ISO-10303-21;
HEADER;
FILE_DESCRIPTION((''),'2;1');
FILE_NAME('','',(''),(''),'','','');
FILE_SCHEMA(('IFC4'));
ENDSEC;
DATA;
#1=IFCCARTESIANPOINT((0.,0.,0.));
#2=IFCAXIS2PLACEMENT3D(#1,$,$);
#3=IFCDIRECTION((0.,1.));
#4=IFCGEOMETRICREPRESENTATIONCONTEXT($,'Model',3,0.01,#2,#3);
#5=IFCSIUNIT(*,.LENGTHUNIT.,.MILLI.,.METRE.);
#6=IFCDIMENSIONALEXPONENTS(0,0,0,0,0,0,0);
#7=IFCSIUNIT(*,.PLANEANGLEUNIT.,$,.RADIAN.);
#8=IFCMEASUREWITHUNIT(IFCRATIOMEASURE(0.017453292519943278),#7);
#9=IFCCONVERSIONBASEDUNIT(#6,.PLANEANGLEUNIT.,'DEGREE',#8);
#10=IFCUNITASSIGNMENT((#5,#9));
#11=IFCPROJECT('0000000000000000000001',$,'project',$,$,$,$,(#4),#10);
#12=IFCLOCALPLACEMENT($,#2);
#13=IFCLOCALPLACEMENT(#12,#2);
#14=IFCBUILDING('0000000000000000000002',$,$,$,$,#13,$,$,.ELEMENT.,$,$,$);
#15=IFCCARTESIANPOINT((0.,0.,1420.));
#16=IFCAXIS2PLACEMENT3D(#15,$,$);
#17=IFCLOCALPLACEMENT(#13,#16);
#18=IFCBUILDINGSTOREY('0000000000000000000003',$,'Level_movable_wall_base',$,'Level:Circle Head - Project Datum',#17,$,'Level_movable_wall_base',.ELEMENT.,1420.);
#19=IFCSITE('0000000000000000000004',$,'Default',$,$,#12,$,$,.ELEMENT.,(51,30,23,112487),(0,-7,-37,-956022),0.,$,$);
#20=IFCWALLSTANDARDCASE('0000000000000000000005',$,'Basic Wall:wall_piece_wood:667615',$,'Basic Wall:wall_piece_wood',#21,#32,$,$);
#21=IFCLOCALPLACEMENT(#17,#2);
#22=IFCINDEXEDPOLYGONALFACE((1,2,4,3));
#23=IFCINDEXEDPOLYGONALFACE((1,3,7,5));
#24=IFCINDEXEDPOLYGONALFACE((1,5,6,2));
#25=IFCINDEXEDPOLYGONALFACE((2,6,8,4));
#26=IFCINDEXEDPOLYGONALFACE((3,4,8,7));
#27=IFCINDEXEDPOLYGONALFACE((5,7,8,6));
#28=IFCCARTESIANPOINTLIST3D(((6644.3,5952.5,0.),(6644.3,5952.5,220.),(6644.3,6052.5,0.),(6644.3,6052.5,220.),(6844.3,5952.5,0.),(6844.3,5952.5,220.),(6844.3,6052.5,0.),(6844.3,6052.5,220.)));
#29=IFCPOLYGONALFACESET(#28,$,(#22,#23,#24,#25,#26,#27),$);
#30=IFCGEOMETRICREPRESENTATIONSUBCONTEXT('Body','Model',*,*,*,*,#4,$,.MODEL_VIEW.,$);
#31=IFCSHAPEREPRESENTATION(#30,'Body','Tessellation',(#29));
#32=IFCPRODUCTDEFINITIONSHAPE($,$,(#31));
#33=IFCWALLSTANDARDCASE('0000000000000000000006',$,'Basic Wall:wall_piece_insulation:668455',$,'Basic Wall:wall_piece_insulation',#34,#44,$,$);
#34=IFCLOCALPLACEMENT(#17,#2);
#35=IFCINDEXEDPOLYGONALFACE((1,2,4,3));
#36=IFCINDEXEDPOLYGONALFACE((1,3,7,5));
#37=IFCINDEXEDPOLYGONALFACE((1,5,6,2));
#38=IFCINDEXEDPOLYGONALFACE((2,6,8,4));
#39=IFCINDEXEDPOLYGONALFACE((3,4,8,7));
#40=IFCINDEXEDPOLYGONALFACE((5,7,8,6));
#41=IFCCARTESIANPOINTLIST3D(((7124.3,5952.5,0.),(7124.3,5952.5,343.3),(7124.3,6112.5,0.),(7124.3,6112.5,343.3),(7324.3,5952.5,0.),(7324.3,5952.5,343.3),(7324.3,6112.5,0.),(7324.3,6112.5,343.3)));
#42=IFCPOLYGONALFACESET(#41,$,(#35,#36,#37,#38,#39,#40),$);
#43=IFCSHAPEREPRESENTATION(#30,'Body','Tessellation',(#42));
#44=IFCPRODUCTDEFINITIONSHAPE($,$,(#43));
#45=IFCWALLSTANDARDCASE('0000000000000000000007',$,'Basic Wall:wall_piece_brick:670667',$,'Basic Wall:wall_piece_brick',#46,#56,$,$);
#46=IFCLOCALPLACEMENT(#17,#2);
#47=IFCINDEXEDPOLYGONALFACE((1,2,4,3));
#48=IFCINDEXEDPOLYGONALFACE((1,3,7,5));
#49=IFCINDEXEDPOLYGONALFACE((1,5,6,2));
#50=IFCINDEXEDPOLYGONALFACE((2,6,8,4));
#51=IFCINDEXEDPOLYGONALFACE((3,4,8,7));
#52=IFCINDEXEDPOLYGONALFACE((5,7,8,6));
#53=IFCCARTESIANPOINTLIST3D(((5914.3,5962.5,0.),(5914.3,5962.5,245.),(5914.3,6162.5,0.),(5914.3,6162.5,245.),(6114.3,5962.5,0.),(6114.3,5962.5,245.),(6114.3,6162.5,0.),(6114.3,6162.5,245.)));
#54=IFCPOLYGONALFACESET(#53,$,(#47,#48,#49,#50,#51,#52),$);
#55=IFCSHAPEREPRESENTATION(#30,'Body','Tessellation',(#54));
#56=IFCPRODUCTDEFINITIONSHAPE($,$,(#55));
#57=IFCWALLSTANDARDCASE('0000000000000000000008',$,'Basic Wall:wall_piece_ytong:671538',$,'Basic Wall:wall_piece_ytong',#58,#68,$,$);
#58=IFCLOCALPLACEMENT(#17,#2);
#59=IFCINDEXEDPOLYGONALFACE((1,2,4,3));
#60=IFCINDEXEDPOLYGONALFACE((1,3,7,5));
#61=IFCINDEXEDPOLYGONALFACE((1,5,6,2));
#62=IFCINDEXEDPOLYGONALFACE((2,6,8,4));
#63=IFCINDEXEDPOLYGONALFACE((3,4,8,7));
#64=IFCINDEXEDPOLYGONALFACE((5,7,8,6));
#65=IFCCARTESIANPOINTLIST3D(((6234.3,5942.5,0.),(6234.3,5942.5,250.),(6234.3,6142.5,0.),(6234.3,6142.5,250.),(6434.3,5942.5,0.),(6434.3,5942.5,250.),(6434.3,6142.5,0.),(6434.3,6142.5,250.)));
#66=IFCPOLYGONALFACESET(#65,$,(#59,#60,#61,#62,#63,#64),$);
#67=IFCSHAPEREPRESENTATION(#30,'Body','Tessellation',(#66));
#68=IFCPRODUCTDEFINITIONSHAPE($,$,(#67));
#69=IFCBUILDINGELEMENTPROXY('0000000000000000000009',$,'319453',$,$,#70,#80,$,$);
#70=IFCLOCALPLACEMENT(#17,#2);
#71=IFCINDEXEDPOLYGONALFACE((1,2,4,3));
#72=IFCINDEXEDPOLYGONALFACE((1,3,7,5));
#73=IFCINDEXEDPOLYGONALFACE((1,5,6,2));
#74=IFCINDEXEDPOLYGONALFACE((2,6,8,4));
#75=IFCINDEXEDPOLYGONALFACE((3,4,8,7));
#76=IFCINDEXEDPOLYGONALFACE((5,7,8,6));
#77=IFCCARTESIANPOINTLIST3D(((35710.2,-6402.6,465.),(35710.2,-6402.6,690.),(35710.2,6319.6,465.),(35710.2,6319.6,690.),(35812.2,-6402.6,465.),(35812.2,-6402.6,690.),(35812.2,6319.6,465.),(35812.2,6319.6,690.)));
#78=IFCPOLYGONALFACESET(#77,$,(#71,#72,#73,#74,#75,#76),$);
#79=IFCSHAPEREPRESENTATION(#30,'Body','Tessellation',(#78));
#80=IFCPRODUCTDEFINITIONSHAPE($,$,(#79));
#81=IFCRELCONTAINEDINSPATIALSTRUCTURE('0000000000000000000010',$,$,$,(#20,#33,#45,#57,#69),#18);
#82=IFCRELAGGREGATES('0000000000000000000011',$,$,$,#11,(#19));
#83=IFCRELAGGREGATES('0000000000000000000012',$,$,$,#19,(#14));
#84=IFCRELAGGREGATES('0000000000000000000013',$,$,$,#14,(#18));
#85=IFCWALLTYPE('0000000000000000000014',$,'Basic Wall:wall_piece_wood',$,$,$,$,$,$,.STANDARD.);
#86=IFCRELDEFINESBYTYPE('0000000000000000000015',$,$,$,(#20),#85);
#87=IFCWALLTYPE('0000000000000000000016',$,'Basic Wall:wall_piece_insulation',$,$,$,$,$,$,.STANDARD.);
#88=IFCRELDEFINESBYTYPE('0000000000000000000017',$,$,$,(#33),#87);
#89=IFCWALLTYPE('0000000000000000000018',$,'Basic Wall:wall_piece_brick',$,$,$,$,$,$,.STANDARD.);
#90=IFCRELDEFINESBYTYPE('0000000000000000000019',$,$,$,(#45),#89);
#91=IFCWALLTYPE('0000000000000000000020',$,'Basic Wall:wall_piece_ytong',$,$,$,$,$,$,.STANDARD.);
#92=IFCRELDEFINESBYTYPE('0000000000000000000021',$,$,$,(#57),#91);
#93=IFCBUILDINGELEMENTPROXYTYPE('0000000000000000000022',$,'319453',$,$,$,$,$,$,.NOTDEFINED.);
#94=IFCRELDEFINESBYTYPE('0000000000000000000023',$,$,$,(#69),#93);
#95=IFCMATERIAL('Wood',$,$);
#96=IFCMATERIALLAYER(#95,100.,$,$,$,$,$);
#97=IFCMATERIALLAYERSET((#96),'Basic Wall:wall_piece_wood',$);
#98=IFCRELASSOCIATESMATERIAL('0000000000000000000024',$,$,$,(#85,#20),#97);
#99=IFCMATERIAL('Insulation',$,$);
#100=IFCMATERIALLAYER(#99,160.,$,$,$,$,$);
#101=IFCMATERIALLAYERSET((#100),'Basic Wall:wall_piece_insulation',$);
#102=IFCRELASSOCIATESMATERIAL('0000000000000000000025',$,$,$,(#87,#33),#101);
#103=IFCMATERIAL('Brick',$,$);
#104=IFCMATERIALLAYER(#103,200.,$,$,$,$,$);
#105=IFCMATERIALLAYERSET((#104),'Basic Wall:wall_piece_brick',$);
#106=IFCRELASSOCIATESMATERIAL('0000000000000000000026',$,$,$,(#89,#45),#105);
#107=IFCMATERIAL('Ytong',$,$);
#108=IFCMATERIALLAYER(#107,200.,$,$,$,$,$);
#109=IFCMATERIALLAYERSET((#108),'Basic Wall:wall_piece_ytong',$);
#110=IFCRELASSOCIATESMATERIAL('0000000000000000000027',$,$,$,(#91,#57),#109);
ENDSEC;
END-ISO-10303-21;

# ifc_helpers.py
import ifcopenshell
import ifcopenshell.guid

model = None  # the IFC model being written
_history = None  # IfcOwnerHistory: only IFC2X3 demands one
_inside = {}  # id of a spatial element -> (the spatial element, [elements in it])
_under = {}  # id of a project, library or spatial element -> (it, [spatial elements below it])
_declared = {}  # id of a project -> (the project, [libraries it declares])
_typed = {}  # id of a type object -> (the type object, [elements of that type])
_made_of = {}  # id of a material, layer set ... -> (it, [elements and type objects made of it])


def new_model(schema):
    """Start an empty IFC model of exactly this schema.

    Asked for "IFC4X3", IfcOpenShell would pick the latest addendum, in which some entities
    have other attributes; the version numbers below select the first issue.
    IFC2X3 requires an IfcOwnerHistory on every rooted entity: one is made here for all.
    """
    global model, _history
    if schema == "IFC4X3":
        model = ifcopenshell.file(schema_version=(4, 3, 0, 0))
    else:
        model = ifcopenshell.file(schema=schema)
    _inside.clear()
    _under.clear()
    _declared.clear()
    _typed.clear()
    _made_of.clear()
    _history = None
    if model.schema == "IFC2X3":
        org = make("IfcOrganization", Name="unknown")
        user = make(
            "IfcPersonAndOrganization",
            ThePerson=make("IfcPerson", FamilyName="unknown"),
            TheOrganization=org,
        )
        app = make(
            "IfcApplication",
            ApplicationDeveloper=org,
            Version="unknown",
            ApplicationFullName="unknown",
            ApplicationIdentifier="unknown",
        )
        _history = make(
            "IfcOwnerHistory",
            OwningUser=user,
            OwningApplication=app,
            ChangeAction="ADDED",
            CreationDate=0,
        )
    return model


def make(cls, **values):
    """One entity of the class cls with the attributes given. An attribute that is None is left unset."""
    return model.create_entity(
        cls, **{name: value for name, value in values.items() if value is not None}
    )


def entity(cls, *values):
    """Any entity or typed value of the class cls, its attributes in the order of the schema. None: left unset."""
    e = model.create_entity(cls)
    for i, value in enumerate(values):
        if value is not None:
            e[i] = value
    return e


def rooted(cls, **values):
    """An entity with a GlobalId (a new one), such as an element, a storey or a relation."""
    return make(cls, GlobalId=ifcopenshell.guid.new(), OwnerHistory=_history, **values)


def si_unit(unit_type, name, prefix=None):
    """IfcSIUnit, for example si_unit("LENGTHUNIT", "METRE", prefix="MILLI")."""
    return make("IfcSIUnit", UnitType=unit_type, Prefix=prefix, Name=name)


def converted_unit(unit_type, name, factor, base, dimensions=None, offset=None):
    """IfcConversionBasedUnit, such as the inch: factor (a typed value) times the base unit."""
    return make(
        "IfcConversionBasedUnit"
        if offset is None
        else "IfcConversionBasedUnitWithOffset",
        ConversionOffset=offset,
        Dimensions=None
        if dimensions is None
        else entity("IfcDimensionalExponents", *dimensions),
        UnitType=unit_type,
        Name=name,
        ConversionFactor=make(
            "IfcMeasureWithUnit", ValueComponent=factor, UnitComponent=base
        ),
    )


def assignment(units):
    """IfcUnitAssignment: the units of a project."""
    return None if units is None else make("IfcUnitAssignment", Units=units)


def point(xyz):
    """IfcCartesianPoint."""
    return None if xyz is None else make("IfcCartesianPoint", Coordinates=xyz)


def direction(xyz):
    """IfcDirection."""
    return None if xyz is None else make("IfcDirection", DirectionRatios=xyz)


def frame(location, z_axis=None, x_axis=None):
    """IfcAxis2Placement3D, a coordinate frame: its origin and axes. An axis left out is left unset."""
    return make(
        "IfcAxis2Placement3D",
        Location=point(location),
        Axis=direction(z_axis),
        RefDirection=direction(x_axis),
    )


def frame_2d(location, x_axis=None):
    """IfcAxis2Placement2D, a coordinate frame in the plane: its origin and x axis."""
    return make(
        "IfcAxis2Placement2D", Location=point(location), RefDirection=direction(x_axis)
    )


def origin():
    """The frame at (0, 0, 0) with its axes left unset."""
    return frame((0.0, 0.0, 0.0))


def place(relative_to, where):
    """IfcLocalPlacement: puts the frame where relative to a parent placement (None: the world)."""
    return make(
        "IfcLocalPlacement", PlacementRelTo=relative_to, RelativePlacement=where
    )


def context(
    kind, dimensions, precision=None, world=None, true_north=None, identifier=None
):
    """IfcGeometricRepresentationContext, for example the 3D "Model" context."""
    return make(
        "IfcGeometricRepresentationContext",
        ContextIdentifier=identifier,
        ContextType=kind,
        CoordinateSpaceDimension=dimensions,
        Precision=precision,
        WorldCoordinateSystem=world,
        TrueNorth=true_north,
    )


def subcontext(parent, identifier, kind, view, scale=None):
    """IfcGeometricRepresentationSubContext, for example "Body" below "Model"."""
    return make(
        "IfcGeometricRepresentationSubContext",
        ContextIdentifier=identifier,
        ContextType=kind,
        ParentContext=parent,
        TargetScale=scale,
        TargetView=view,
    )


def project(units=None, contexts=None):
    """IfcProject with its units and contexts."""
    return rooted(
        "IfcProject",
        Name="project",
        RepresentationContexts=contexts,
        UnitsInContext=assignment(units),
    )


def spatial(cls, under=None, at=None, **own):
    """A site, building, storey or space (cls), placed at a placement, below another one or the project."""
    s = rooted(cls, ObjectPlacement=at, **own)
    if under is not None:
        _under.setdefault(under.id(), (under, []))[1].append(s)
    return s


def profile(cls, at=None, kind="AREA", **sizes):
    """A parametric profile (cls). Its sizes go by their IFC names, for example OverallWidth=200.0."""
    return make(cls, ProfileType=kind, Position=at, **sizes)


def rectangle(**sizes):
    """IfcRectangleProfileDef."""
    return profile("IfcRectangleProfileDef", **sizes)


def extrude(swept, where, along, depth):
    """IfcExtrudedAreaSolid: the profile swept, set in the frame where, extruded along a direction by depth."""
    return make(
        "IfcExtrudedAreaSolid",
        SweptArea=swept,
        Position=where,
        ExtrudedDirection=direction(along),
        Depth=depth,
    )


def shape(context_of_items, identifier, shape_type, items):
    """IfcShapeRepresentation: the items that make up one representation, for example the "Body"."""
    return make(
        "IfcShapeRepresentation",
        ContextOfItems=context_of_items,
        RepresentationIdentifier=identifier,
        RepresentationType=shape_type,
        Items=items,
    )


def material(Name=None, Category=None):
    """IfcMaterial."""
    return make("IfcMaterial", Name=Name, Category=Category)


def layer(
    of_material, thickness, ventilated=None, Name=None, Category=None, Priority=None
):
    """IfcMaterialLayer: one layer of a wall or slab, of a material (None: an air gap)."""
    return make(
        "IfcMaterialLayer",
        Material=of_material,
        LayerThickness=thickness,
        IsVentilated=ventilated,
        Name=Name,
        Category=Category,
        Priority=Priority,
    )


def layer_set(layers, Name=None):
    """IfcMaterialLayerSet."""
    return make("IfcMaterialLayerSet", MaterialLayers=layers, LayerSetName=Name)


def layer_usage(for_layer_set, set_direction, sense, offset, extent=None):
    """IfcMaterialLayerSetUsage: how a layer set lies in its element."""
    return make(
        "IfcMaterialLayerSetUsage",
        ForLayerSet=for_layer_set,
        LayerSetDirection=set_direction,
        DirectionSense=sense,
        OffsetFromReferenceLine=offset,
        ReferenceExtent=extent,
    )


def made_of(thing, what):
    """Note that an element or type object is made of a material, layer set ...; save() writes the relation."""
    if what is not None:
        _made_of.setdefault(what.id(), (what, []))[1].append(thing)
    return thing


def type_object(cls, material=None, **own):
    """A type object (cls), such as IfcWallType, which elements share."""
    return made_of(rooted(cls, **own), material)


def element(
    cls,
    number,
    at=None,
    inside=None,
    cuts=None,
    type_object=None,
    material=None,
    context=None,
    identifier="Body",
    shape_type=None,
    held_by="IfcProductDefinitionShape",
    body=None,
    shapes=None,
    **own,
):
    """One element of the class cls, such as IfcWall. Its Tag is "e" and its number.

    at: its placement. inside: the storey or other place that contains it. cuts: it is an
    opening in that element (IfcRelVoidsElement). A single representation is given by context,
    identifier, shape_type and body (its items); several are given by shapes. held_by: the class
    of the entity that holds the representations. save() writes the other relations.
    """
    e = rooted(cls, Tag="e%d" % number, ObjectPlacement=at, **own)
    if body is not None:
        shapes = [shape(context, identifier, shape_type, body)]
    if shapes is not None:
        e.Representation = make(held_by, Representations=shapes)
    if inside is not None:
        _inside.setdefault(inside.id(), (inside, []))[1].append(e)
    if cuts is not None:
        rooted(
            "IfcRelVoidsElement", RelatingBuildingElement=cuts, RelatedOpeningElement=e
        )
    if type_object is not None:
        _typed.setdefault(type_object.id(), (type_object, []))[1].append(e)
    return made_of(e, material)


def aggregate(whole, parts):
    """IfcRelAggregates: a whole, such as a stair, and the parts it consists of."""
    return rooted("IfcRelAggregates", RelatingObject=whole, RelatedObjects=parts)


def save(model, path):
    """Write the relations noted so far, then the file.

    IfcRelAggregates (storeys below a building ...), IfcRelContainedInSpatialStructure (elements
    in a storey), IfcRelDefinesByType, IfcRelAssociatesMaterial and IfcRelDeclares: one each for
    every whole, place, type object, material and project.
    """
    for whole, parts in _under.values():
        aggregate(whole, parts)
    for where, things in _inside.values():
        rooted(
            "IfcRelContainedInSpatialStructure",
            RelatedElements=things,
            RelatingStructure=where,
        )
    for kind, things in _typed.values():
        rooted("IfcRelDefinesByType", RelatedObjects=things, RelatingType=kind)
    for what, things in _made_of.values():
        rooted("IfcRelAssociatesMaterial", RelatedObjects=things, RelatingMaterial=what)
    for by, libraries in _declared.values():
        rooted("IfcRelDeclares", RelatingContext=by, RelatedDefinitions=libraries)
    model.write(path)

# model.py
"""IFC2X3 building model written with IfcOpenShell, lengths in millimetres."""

from ifc_helpers import new_model, entity, si_unit, converted_unit, direction, frame, frame_2d, origin, place, context, subcontext, project, spatial, rectangle, extrude, material, layer, layer_set, layer_usage, type_object, element, save


model = new_model("IFC2X3")

# Units and contexts
model_context = context("Model", 3, precision=0.01, world=origin(), true_north=direction((0.0, 1.0)))
body_context = subcontext(model_context, "Body", "Model", "MODEL_VIEW")
ifc_project = project(units=[si_unit("LENGTHUNIT", "METRE", prefix="MILLI"), converted_unit("PLANEANGLEUNIT", "DEGREE", entity("IfcRatioMeasure", 0.017453292519943278), si_unit("PLANEANGLEUNIT", "RADIAN"), dimensions=[0, 0, 0, 0, 0, 0, 0])], contexts=[model_context])

# Site, building, storey
site_placement = place(None, origin())
site = spatial("IfcSite", under=ifc_project, at=site_placement, Name="Default", CompositionType="ELEMENT", RefLatitude=(51, 30, 23, 112487), RefLongitude=(0, -7, -37, -956022), RefElevation=0.0)
building_placement = place(site_placement, origin())
building = spatial("IfcBuilding", under=site, at=building_placement, CompositionType="ELEMENT")
storey_placement = place(building_placement, frame((0.0, 0.0, 1420.0)))
storey = spatial("IfcBuildingStorey", under=building, at=storey_placement, Name="Level_movable_wall_base", ObjectType="Level:Circle Head - Project Datum", LongName="Level_movable_wall_base", CompositionType="ELEMENT", Elevation=1420.0)

# Walls
ifc_material_1 = material(Name="Wood")
ifc_layer_1 = layer(ifc_material_1, 100.0)
ifc_layer_set_1 = layer_set([ifc_layer_1], Name="Basic Wall:wall_piece_wood")
ifc_layer_usage_1 = layer_usage(ifc_layer_set_1, "AXIS2", "NEGATIVE", 50.0)
wall_type_1 = type_object("IfcWallType", Name="Basic Wall:wall_piece_wood", PredefinedType="STANDARD", material=ifc_layer_set_1)
wall_1_placement = place(storey_placement, frame((6644.3, 6002.5, 0.0)))
element("IfcWallStandardCase", 1, at=wall_1_placement, inside=storey, type_object=wall_type_1, material=ifc_layer_usage_1, Name="Basic Wall:wall_piece_wood:667615", ObjectType="Basic Wall:wall_piece_wood", context=body_context, shape_type="SweptSolid", body=[
    extrude(rectangle(XDim=200.0, YDim=100.0, at=frame_2d((100.0, 0.0), x_axis=(-1.0, 0.0))), origin(), (0.0, 0.0, 1.0), 220.0),
])
ifc_material_2 = material(Name="Insulation")
ifc_layer_2 = layer(ifc_material_2, 160.0)
ifc_layer_set_2 = layer_set([ifc_layer_2], Name="Basic Wall:wall_piece_insulation")
ifc_layer_usage_2 = layer_usage(ifc_layer_set_2, "AXIS2", "NEGATIVE", 80.0)
wall_type_2 = type_object("IfcWallType", Name="Basic Wall:wall_piece_insulation", PredefinedType="STANDARD", material=ifc_layer_set_2)
wall_2_placement = place(storey_placement, frame((7124.3, 6032.5, 0.0)))
element("IfcWallStandardCase", 2, at=wall_2_placement, inside=storey, type_object=wall_type_2, material=ifc_layer_usage_2, Name="Basic Wall:wall_piece_insulation:668455", ObjectType="Basic Wall:wall_piece_insulation", context=body_context, shape_type="SweptSolid", body=[
    extrude(rectangle(XDim=200.0, YDim=160.0, at=frame_2d((100.0, 0.0), x_axis=(-1.0, 0.0))), origin(), (0.0, 0.0, 1.0), 343.3),
])
ifc_material_3 = material(Name="Brick")
ifc_layer_3 = layer(ifc_material_3, 200.0)
ifc_layer_set_3 = layer_set([ifc_layer_3], Name="Basic Wall:wall_piece_brick")
ifc_layer_usage_3 = layer_usage(ifc_layer_set_3, "AXIS2", "NEGATIVE", 100.0)
wall_type_3 = type_object("IfcWallType", Name="Basic Wall:wall_piece_brick", PredefinedType="STANDARD", material=ifc_layer_set_3)
wall_3_placement = place(storey_placement, frame((5914.3, 6062.5, 0.0)))
element("IfcWallStandardCase", 3, at=wall_3_placement, inside=storey, type_object=wall_type_3, material=ifc_layer_usage_3, Name="Basic Wall:wall_piece_brick:670667", ObjectType="Basic Wall:wall_piece_brick", context=body_context, shape_type="SweptSolid", body=[
    extrude(rectangle(XDim=200.0, YDim=200.0, at=frame_2d((100.0, 0.0), x_axis=(-1.0, 0.0))), origin(), (0.0, 0.0, 1.0), 245.0),
])
ifc_material_4 = material(Name="Ytong")
ifc_layer_4 = layer(ifc_material_4, 200.0)
ifc_layer_set_4 = layer_set([ifc_layer_4], Name="Basic Wall:wall_piece_ytong")
ifc_layer_usage_4 = layer_usage(ifc_layer_set_4, "AXIS2", "NEGATIVE", 100.0)
wall_type_4 = type_object("IfcWallType", Name="Basic Wall:wall_piece_ytong", PredefinedType="STANDARD", material=ifc_layer_set_4)
wall_4_placement = place(storey_placement, frame((6234.3, 6042.5, 0.0)))
element("IfcWallStandardCase", 4, at=wall_4_placement, inside=storey, type_object=wall_type_4, material=ifc_layer_usage_4, Name="Basic Wall:wall_piece_ytong:671538", ObjectType="Basic Wall:wall_piece_ytong", context=body_context, shape_type="SweptSolid", body=[
    extrude(rectangle(XDim=200.0, YDim=200.0, at=frame_2d((100.0, 0.0), x_axis=(-1.0, 0.0))), origin(), (0.0, 0.0, 1.0), 250.0),
])

# Building element proxy
building_element_proxy_type = type_object("IfcBuildingElementProxyType", Name="319453", PredefinedType="NOTDEFINED")
proxy_placement = place(storey_placement, origin())
element("IfcBuildingElementProxy", 5, at=proxy_placement, inside=storey, type_object=building_element_proxy_type, Name="319453", context=body_context, shape_type="SweptSolid", body=[
    extrude(rectangle(XDim=12722.3, YDim=102.0, at=frame_2d((0.0, 0.0), x_axis=(1.0, 0.0))), frame((35761.2, -41.5, 465.0), z_axis=(0.0, 0.0, 1.0), x_axis=(0.0, -1.0, 0.0)), (0.0, 0.0, 1.0), 225.0),
])

save(model, "model.ifc")
